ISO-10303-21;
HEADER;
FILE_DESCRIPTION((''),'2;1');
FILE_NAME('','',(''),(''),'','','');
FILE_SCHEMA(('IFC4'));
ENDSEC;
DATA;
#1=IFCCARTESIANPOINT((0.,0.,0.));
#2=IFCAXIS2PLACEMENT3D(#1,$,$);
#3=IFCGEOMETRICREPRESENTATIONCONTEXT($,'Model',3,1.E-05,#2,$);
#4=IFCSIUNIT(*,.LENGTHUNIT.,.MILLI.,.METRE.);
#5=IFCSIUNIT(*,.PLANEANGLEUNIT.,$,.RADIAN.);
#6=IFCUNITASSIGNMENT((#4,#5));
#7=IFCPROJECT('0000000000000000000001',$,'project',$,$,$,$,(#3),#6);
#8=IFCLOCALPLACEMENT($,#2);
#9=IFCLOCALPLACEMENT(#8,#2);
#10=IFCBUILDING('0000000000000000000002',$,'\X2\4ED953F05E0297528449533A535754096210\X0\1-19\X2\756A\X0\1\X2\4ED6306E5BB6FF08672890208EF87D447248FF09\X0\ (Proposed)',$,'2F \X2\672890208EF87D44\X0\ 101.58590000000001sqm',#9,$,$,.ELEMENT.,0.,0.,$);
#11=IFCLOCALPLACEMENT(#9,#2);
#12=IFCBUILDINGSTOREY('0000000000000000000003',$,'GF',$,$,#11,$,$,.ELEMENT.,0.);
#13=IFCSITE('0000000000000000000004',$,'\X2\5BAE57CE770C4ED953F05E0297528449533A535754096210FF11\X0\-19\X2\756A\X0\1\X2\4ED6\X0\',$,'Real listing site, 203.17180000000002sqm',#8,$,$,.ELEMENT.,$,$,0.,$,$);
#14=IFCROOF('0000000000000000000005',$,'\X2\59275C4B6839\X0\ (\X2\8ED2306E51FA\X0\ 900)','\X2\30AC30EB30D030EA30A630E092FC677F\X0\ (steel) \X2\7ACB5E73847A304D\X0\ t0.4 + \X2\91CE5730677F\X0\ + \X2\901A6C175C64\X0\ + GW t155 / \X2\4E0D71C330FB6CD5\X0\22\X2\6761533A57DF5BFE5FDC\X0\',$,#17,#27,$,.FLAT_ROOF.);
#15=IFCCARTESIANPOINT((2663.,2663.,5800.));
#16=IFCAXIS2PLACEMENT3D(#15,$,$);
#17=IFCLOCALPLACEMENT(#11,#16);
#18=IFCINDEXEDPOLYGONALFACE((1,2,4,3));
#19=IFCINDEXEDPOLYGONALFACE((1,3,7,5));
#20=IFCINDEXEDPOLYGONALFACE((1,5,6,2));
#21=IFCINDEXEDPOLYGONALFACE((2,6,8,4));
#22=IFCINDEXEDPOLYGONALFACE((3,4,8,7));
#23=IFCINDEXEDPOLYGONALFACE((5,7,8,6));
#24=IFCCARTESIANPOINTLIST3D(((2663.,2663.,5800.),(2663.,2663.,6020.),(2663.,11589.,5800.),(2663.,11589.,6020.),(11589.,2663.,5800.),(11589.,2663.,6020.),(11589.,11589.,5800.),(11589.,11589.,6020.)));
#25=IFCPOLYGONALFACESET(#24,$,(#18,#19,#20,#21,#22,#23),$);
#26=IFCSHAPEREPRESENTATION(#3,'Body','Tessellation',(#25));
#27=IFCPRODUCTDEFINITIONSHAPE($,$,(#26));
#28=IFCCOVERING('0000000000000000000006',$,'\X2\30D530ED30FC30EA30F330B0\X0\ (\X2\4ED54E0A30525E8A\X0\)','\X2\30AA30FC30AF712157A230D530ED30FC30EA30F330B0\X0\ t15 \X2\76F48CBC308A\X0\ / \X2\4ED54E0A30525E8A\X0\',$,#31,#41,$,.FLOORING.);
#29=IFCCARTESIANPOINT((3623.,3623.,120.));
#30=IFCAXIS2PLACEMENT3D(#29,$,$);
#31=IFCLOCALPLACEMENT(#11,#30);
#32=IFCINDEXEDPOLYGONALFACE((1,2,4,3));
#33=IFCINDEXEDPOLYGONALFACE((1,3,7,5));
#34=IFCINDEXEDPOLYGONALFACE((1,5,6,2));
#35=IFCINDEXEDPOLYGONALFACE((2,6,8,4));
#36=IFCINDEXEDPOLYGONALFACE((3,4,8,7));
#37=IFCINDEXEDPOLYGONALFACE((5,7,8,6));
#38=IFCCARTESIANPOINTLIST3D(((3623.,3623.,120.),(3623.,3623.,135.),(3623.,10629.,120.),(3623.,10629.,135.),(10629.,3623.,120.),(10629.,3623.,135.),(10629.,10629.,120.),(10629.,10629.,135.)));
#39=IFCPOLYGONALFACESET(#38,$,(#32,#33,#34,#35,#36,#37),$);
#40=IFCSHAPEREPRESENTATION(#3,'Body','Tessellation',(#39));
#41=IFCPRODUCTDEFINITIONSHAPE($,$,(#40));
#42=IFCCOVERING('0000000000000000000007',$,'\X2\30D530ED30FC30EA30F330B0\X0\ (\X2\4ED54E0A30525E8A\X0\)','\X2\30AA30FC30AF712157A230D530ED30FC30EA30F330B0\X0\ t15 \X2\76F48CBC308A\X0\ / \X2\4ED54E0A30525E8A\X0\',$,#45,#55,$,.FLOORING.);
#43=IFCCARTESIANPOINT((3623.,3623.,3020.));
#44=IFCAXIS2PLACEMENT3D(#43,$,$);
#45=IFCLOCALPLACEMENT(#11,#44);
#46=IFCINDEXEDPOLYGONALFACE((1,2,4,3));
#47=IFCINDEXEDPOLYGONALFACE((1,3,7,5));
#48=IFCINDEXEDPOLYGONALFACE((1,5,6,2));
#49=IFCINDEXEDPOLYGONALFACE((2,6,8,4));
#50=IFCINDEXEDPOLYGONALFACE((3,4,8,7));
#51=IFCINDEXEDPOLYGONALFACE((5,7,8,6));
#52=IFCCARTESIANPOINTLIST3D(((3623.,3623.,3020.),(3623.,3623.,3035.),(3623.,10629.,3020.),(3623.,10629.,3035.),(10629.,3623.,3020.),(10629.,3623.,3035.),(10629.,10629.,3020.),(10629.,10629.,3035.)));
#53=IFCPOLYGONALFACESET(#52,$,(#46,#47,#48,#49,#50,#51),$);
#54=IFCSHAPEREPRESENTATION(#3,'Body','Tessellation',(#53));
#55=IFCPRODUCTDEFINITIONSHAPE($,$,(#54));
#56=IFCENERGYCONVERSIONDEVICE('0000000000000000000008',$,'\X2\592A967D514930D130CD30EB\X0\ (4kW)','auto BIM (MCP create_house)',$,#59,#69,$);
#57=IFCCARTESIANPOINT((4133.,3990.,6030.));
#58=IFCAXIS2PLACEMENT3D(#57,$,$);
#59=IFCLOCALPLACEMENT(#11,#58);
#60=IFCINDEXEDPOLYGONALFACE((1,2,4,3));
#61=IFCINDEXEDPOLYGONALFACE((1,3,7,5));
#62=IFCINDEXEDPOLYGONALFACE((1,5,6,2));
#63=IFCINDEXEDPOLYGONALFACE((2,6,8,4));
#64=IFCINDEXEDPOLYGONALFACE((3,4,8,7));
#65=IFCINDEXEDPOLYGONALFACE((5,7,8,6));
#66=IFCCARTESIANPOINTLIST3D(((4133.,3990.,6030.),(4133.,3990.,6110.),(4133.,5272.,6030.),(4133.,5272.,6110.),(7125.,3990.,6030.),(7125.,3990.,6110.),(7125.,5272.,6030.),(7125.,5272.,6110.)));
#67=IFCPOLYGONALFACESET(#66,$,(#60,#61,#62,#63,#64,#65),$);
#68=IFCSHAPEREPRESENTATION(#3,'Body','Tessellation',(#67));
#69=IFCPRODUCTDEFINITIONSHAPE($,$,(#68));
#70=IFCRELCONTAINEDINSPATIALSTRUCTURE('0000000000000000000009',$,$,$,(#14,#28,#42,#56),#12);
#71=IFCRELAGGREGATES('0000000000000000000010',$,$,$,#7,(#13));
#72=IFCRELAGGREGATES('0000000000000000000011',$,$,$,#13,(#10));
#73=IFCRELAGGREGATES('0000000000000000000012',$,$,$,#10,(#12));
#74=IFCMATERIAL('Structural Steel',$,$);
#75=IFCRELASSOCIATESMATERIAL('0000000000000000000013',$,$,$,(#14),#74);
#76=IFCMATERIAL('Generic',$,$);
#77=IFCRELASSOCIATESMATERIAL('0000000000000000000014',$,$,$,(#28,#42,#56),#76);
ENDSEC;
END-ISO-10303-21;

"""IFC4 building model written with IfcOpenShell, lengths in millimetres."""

from ifc_helpers import new_model, si_unit, frame, frame_2d, origin, place, context, project, spatial, rectangle, extrude, material, element, save


model = new_model("IFC4")

# Units and contexts
model_context = context("Model", 3, precision=1e-05, world=origin())
ifc_project = project(units=[si_unit("LENGTHUNIT", "METRE", prefix="MILLI"), si_unit("PLANEANGLEUNIT", "RADIAN")], contexts=[model_context])

# Site, building, storey
site_placement = place(None, origin())
site = spatial("IfcSite", under=ifc_project, at=site_placement, Name="宮城県仙台市青葉区南吉成１-19番1他", ObjectType="Real listing site, 203.17180000000002sqm", CompositionType="ELEMENT", RefElevation=0.0)
building_placement = place(site_placement, origin())
building = spatial("IfcBuilding", under=site, at=building_placement, Name="仙台市青葉区南吉成1-19番1他の家（木造軸組版） (Proposed)", ObjectType="2F 木造軸組 101.58590000000001sqm", CompositionType="ELEMENT", ElevationOfRefHeight=0.0, ElevationOfTerrain=0.0)
storey_placement = place(building_placement, origin())
storey = spatial("IfcBuildingStorey", under=building, at=storey_placement, Name="GF", CompositionType="ELEMENT", Elevation=0.0)

# Roof
ifc_material_1 = material(Name="Structural Steel")
roof_placement = place(storey_placement, frame((2663.0, 2663.0, 5800.0)))
element("IfcRoof", 1, at=roof_placement, inside=storey, material=ifc_material_1, Name="大屋根 (軒の出 900)", Description="ガルバリウム鋼板 (steel) 立平葺き t0.4 + 野地板 + 通気層 + GW t155 / 不燃・法22条区域対応", PredefinedType="FLAT_ROOF", context=model_context, shape_type="SweptSolid", body=[
    extrude(rectangle(XDim=8926.0, YDim=8926.0, at=frame_2d((4463.0, 4463.0))), frame((2663.0, 2663.0, 5800.0)), (0.0, 0.0, 1.0), 220.0),
])

# Coverings
ifc_material_2 = material(Name="Generic")
covering_1_placement = place(storey_placement, frame((3623.0, 3623.0, 120.0)))
element("IfcCovering", 2, at=covering_1_placement, inside=storey, material=ifc_material_2, Name="フローリング (仕上げ床)", Description="オーク無垢フローリング t15 直貼り / 仕上げ床", PredefinedType="FLOORING", context=model_context, shape_type="SweptSolid", body=[
    extrude(rectangle(XDim=7006.0, YDim=7006.0, at=frame_2d((3503.0, 3503.0))), frame((3623.0, 3623.0, 120.0)), (0.0, 0.0, 1.0), 15.0),
])
covering_2_placement = place(storey_placement, frame((3623.0, 3623.0, 3020.0)))
element("IfcCovering", 3, at=covering_2_placement, inside=storey, material=ifc_material_2, Name="フローリング (仕上げ床)", Description="オーク無垢フローリング t15 直貼り / 仕上げ床", PredefinedType="FLOORING", context=model_context, shape_type="SweptSolid", body=[
    extrude(rectangle(XDim=7006.0, YDim=7006.0, at=frame_2d((3503.0, 3503.0))), frame((3623.0, 3623.0, 3020.0)), (0.0, 0.0, 1.0), 15.0),
])

# Energy conversion device
energy_conversion_device_placement = place(storey_placement, frame((4133.0, 3990.0, 6030.0)))
element("IfcEnergyConversionDevice", 4, at=energy_conversion_device_placement, inside=storey, material=ifc_material_2, Name="太陽光パネル (4kW)", Description="auto BIM (MCP create_house)", context=model_context, shape_type="SweptSolid", body=[
    extrude(rectangle(XDim=2992.0, YDim=1282.0, at=frame_2d((1496.0, 641.0))), frame((4133.0, 3990.0, 6030.0)), (0.0, 0.0, 1.0), 80.0),
])

save(model, "model.ifc")
